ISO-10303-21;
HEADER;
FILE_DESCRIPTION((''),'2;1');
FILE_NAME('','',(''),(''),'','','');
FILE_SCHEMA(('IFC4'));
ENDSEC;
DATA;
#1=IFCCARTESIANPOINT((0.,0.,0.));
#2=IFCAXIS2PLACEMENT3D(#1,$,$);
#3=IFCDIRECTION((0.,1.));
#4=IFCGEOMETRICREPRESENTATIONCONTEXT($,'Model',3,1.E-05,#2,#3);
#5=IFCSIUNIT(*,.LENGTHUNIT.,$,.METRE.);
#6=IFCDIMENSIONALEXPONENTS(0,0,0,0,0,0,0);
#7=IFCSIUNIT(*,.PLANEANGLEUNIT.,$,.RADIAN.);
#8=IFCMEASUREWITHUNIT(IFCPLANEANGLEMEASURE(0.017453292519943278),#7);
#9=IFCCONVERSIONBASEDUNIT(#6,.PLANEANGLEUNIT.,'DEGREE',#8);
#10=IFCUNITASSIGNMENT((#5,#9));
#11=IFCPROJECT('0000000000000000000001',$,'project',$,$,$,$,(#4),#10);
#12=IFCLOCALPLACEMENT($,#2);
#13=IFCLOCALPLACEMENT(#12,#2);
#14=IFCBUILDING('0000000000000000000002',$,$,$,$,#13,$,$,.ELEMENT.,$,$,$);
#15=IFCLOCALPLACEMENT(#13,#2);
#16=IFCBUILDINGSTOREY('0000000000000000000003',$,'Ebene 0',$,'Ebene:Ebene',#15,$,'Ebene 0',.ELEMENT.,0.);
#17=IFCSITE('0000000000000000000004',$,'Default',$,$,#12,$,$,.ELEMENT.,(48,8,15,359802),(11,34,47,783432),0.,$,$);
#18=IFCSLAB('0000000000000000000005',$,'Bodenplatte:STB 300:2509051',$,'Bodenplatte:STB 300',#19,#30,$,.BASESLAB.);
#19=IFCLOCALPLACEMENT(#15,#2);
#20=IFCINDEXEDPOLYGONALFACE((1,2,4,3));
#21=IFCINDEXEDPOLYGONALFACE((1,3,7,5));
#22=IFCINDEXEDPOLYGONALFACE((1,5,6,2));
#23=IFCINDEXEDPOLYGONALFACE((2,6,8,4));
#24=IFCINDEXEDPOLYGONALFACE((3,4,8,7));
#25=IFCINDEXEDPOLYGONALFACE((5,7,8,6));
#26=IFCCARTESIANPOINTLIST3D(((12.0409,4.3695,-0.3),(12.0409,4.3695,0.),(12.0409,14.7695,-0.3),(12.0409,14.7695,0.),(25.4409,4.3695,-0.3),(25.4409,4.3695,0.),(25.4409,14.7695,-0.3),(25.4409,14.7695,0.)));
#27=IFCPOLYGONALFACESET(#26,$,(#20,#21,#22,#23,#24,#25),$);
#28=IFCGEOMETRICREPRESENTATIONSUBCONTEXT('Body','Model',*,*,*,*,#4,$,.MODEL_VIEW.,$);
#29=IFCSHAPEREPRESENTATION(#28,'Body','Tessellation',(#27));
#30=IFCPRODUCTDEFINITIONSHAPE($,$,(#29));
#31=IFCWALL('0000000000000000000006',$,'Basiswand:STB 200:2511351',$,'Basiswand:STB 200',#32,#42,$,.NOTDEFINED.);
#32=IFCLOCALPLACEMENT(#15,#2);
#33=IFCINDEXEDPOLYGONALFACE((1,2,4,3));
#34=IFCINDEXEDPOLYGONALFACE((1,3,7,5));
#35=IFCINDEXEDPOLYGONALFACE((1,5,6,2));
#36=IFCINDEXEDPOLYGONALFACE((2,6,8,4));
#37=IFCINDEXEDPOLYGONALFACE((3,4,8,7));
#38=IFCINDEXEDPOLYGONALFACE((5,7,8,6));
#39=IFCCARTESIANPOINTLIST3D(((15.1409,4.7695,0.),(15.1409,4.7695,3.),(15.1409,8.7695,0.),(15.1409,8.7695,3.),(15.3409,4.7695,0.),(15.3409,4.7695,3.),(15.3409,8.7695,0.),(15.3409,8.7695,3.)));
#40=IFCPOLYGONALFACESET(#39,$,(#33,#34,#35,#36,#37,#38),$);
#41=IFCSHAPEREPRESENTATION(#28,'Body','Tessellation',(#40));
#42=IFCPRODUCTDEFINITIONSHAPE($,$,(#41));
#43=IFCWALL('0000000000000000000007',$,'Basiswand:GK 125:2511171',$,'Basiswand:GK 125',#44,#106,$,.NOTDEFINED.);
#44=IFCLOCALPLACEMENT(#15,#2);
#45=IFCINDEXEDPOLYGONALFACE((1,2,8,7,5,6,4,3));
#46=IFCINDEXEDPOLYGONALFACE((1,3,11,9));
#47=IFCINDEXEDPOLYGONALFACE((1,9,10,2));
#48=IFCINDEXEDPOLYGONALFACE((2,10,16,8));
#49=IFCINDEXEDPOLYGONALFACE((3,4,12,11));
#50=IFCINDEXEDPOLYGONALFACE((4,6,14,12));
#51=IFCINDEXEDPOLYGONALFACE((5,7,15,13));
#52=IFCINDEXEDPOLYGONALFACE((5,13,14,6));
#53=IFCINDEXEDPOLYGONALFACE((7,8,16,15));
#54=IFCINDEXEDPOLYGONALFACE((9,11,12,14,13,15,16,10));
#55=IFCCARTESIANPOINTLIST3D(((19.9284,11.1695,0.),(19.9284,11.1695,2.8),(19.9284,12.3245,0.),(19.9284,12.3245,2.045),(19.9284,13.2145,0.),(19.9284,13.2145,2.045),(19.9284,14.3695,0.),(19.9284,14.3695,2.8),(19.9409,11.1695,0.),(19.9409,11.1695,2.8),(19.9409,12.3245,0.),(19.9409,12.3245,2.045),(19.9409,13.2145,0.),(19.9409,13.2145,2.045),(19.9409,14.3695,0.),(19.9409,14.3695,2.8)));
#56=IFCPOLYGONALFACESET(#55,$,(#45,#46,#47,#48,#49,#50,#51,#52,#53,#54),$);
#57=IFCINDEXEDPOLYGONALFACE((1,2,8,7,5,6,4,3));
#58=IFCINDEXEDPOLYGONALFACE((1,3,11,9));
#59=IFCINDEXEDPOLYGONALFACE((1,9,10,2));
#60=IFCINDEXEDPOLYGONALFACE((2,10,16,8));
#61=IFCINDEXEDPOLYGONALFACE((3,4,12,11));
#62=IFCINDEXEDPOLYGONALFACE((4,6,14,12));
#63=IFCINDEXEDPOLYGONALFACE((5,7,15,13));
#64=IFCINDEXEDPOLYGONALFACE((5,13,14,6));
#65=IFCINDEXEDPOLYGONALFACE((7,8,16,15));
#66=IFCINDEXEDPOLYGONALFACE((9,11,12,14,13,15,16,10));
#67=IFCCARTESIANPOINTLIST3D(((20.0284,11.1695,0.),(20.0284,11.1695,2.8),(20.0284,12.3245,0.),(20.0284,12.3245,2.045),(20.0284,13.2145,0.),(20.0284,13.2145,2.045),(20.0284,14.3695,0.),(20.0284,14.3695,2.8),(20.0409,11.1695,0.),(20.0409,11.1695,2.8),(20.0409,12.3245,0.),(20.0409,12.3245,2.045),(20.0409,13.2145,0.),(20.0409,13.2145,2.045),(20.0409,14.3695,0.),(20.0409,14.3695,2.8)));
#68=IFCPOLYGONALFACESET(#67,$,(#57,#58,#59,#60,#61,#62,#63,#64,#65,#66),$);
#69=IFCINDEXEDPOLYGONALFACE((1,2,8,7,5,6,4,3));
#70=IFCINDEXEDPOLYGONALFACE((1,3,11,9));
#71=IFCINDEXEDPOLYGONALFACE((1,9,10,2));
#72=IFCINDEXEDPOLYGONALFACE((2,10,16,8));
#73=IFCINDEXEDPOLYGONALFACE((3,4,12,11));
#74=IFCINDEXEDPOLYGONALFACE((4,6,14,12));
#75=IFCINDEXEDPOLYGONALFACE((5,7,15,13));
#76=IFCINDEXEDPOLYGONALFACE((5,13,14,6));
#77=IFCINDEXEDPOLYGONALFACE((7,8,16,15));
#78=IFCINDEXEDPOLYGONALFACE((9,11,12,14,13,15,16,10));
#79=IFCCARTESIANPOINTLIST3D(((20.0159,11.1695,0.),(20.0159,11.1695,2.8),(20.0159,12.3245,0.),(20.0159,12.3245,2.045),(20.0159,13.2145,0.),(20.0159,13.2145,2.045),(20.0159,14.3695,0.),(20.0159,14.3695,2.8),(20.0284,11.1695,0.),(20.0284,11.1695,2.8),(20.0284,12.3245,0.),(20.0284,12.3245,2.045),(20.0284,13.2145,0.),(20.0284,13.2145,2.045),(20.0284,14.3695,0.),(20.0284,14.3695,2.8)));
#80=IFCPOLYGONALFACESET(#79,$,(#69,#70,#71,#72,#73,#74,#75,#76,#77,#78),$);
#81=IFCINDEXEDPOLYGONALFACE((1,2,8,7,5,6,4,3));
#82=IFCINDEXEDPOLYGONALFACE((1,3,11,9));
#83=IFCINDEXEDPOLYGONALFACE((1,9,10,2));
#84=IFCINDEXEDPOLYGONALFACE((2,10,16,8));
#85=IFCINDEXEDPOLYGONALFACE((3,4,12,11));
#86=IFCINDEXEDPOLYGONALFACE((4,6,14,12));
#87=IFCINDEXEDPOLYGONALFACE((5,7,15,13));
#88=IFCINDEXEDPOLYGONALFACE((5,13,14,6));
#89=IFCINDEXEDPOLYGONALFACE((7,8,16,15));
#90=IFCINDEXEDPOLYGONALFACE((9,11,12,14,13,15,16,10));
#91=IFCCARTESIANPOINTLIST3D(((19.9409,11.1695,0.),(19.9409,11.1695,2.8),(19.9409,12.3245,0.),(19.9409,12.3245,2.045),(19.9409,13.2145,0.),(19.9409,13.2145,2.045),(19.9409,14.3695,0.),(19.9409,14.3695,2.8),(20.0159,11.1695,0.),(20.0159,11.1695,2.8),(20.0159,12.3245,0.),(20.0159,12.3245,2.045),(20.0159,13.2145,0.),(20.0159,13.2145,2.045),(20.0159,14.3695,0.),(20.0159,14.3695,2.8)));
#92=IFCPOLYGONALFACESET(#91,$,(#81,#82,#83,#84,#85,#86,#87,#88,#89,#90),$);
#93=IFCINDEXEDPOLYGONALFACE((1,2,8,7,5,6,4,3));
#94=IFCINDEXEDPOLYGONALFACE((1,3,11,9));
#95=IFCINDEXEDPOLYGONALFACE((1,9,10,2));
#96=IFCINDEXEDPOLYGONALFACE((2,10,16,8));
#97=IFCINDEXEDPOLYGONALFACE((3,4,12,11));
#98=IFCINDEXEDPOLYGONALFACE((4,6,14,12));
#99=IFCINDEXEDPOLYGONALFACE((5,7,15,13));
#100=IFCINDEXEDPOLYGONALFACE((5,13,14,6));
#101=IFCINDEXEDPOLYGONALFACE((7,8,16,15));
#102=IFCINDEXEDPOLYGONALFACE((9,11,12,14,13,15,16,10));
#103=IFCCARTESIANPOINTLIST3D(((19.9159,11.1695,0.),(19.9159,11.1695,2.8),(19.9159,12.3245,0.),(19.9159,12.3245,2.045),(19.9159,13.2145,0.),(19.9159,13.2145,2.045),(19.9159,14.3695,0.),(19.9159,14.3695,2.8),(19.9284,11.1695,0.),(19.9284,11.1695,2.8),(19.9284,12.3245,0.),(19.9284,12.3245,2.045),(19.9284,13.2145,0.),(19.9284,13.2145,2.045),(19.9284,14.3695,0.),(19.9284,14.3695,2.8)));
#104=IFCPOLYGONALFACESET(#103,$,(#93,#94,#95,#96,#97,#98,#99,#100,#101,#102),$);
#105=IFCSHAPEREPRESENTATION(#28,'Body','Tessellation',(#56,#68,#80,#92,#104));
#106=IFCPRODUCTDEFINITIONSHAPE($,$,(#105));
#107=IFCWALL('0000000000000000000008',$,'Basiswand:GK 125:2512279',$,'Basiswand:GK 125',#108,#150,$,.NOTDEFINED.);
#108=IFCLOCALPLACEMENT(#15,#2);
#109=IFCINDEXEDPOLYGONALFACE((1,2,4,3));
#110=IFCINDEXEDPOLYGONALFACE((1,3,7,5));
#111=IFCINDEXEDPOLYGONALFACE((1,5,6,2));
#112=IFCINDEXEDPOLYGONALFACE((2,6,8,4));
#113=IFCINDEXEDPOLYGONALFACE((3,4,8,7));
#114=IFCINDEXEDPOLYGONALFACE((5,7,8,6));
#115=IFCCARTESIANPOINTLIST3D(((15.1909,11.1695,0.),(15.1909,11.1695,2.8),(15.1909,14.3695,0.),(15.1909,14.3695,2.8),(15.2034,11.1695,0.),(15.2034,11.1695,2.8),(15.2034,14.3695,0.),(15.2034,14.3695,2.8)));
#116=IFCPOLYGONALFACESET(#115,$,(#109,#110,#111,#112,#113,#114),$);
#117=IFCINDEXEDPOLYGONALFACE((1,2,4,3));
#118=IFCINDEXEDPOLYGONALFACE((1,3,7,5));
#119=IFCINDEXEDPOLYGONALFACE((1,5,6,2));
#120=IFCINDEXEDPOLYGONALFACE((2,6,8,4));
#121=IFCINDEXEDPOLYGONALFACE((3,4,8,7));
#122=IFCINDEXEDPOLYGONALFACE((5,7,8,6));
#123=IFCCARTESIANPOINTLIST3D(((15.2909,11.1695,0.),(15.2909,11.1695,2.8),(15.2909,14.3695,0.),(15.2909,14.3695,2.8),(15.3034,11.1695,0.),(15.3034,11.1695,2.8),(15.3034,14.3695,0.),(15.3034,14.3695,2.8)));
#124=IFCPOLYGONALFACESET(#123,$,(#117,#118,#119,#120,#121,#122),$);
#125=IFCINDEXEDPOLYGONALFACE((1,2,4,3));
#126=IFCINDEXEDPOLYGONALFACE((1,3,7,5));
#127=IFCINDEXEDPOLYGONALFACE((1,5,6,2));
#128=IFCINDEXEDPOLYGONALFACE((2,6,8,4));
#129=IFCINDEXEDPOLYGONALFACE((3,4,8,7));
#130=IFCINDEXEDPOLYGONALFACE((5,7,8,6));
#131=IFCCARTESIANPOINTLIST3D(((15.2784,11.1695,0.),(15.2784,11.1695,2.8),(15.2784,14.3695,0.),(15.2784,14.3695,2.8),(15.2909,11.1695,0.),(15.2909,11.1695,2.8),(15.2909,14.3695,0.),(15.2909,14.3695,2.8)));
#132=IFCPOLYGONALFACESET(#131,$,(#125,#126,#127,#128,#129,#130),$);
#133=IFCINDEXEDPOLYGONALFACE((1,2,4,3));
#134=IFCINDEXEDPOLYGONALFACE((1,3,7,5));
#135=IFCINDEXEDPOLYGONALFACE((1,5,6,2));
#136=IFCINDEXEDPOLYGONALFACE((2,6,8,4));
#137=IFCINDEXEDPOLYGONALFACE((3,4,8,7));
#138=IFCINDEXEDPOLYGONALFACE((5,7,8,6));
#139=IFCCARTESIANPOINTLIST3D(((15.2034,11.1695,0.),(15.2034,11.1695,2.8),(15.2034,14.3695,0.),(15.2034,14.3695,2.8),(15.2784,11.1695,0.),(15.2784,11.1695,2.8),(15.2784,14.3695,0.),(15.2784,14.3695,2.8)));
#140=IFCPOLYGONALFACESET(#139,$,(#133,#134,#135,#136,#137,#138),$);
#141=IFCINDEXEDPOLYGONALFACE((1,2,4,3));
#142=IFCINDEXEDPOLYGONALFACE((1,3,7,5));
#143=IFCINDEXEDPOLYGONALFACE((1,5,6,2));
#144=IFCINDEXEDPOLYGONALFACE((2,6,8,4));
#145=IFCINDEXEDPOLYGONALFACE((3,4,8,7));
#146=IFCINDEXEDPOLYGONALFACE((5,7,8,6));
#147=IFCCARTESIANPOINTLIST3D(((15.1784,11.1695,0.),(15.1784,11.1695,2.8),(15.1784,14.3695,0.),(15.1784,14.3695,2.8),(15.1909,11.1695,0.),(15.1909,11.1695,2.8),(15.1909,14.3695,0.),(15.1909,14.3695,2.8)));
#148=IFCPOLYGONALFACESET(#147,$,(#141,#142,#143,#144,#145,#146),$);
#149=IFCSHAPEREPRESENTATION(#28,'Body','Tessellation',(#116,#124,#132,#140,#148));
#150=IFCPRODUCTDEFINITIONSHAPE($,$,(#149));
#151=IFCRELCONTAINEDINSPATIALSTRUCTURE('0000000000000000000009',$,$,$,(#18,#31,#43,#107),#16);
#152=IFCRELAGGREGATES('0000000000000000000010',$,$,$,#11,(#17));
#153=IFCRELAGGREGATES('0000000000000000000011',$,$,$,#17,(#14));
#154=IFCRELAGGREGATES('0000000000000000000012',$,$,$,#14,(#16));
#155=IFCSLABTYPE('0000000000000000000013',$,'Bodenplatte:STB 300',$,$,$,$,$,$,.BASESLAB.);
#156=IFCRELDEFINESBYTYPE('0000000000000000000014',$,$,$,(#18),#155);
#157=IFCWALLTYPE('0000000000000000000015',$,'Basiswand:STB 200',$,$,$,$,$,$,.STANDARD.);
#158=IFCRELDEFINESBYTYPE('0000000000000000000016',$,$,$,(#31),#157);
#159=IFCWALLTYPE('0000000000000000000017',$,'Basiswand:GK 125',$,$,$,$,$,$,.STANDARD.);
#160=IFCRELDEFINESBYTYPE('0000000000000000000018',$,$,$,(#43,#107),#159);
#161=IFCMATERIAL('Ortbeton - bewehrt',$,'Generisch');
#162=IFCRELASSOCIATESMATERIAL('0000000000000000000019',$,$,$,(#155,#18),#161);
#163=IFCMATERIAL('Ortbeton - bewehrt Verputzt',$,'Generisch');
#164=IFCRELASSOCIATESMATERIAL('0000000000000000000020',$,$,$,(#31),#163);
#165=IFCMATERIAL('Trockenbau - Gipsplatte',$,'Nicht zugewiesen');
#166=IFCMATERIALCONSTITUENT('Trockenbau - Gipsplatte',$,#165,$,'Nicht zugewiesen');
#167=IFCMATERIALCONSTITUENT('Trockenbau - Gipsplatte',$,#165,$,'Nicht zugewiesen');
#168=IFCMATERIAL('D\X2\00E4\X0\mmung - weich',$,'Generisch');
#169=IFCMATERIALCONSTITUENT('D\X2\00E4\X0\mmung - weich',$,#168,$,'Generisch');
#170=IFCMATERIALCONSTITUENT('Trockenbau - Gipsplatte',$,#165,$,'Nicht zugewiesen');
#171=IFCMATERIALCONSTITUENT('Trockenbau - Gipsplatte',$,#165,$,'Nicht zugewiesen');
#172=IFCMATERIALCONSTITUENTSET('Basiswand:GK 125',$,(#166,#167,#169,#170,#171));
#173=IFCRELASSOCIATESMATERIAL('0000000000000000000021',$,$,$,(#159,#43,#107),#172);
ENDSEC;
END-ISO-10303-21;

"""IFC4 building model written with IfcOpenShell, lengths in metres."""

from ifc_helpers import new_model, entity, si_unit, converted_unit, direction, frame, origin, place, context, subcontext, project, spatial, indexed_curve, outline, extrude, material, constituent, constituent_set, type_object, element, save


model = new_model("IFC4")

# Units and contexts
model_context = context("Model", 3, precision=1e-05, world=origin(), true_north=direction((0.0, 1.0)))
body_context = subcontext(model_context, "Body", "Model", "MODEL_VIEW")
ifc_project = project(units=[si_unit("LENGTHUNIT", "METRE"), converted_unit("PLANEANGLEUNIT", "DEGREE", entity("IfcPlaneAngleMeasure", 0.017453292519943278), si_unit("PLANEANGLEUNIT", "RADIAN"), dimensions=[0, 0, 0, 0, 0, 0, 0])], contexts=[model_context])

# Site, building, storey
site_placement = place(None, origin())
site = spatial("IfcSite", under=ifc_project, at=site_placement, Name="Default", CompositionType="ELEMENT", RefLatitude=(48, 8, 15, 359802), RefLongitude=(11, 34, 47, 783432), RefElevation=0.0)
building_placement = place(site_placement, origin())
building = spatial("IfcBuilding", under=site, at=building_placement, CompositionType="ELEMENT")
storey_placement = place(building_placement, origin())
storey = spatial("IfcBuildingStorey", under=building, at=storey_placement, Name="Ebene 0", ObjectType="Ebene:Ebene", LongName="Ebene 0", CompositionType="ELEMENT", Elevation=0.0)

# Slab
ifc_material_1 = material(Name="Ortbeton - bewehrt", Category="Generisch")
slab_type_1 = type_object("IfcSlabType", Name="Bodenplatte:STB 300", PredefinedType="BASESLAB", material=ifc_material_1)
slab_1_placement = place(storey_placement, origin())
element("IfcSlab", 1, at=slab_1_placement, inside=storey, type_object=slab_type_1, material=ifc_material_1, Name="Bodenplatte:STB 300:2509051", ObjectType="Bodenplatte:STB 300", PredefinedType="BASESLAB", context=body_context, shape_type="SweptSolid", body=[
    extrude(outline(indexed_curve([(-5.2, -6.7), (5.2, -6.7), (5.2, 6.7), (-5.2, 6.7), (-5.2, -6.7)], self_intersect=False)), frame((18.7409, 9.5695, 0.0), z_axis=(0.0, 0.0, -1.0), x_axis=(0.0, 1.0, 0.0)), (0.0, 0.0, 1.0), 0.3),
])

# Wall
ifc_material_2 = material(Name="Ortbeton - bewehrt Verputzt", Category="Generisch")
wall_type_1 = type_object("IfcWallType", Name="Basiswand:STB 200", PredefinedType="STANDARD")
wall_1_placement = place(storey_placement, frame((15.2409, 8.7695, 0.0), z_axis=(0.0, 0.0, 1.0), x_axis=(0.0, -1.0, 0.0)))
element("IfcWall", 2, at=wall_1_placement, inside=storey, type_object=wall_type_1, material=ifc_material_2, Name="Basiswand:STB 200:2511351", ObjectType="Basiswand:STB 200", PredefinedType="NOTDEFINED", context=body_context, shape_type="SweptSolid", body=[
    extrude(outline(indexed_curve([(4.0, 0.1), (0.0, 0.1), (0.0, -0.1), (4.0, -0.1), (4.0, 0.1)], self_intersect=False)), origin(), (0.0, 0.0, 1.0), 3.0),
])

# Wall, opening
ifc_material_3 = material(Name="Trockenbau - Gipsplatte", Category="Nicht zugewiesen")
ifc_constituent_1 = constituent(ifc_material_3, Name="Trockenbau - Gipsplatte", Category="Nicht zugewiesen")
ifc_constituent_2 = constituent(ifc_material_3, Name="Trockenbau - Gipsplatte", Category="Nicht zugewiesen")
ifc_material_4 = material(Name="Dämmung - weich", Category="Generisch")
ifc_constituent_3 = constituent(ifc_material_4, Name="Dämmung - weich", Category="Generisch")
ifc_constituent_4 = constituent(ifc_material_3, Name="Trockenbau - Gipsplatte", Category="Nicht zugewiesen")
ifc_constituent_5 = constituent(ifc_material_3, Name="Trockenbau - Gipsplatte", Category="Nicht zugewiesen")
ifc_constituent_set_1 = constituent_set(constituents=[ifc_constituent_1, ifc_constituent_2, ifc_constituent_3, ifc_constituent_4, ifc_constituent_5], Name="Basiswand:GK 125")
wall_type_2 = type_object("IfcWallType", Name="Basiswand:GK 125", PredefinedType="STANDARD", material=ifc_constituent_set_1)
wall_2_placement = place(storey_placement, frame((19.9784, 14.3695, 0.0), z_axis=(0.0, 0.0, 1.0), x_axis=(0.0, -1.0, 0.0)))
wall_2 = element("IfcWall", 3, at=wall_2_placement, inside=storey, type_object=wall_type_2, material=ifc_constituent_set_1, Name="Basiswand:GK 125:2511171", ObjectType="Basiswand:GK 125", PredefinedType="NOTDEFINED", context=body_context, shape_type="SweptSolid", body=[
    extrude(outline(indexed_curve([(-1.2112, -1.6), (1.5888, -1.6), (1.5888, 1.6), (-1.2112, 1.6), (-1.2112, 0.445), (0.8337, 0.445), (0.8337, -0.445), (-1.2112, -0.445), (-1.2112, -1.6)], self_intersect=False)), frame((1.6, -0.05, 1.2112), z_axis=(0.0, 1.0, 0.0), x_axis=(0.0, 0.0, 1.0)), (0.0, 0.0, 1.0), 0.0125),
    extrude(outline(indexed_curve([(-1.2112, -1.6), (1.5888, -1.6), (1.5888, 1.6), (-1.2112, 1.6), (-1.2112, 0.445), (0.8337, 0.445), (0.8337, -0.445), (-1.2112, -0.445), (-1.2112, -1.6)], self_intersect=False)), frame((1.6, 0.05, 1.2112), z_axis=(0.0, 1.0, 0.0), x_axis=(0.0, 0.0, 1.0)), (0.0, 0.0, 1.0), 0.0125),
    extrude(outline(indexed_curve([(-1.2112, -1.6), (1.5888, -1.6), (1.5888, 1.6), (-1.2112, 1.6), (-1.2112, 0.445), (0.8337, 0.445), (0.8337, -0.445), (-1.2112, -0.445), (-1.2112, -1.6)], self_intersect=False)), frame((1.6, 0.0375, 1.2112), z_axis=(0.0, 1.0, 0.0), x_axis=(0.0, 0.0, 1.0)), (0.0, 0.0, 1.0), 0.0125),
    extrude(outline(indexed_curve([(-1.2112, -1.6), (1.5888, -1.6), (1.5888, 1.6), (-1.2112, 1.6), (-1.2112, 0.445), (0.8337, 0.445), (0.8337, -0.445), (-1.2112, -0.445), (-1.2112, -1.6)], self_intersect=False)), frame((1.6, -0.0375, 1.2112), z_axis=(0.0, 1.0, 0.0), x_axis=(0.0, 0.0, 1.0)), (0.0, 0.0, 1.0), 0.075),
    extrude(outline(indexed_curve([(-1.5888, -1.6), (1.2112, -1.6), (1.2112, -0.445), (-0.8337, -0.445), (-0.8337, 0.445), (1.2112, 0.445), (1.2112, 1.6), (-1.5888, 1.6), (-1.5888, -1.6)], self_intersect=False)), frame((1.6, -0.0625, 1.2112), z_axis=(0.0, 1.0, 0.0), x_axis=(0.0, 0.0, -1.0)), (0.0, 0.0, 1.0), 0.0125),
])
opening_1_placement = place(wall_2_placement, frame((2.045, 0.0625, -0.18)))
element("IfcOpeningElement", 4, at=opening_1_placement, cuts=wall_2, PredefinedType="OPENING", context=body_context, shape_type="SweptSolid", body=[
    extrude(outline(indexed_curve([(2.225, 0.89), (0.0, 0.89), (0.0, 0.0), (2.225, 0.0), (2.225, 0.89)], self_intersect=False)), frame((0.0, 0.0, 0.0), z_axis=(0.0, -1.0, 0.0), x_axis=(0.0, 0.0, 1.0)), (0.0, 0.0, 1.0), 0.125),
])

# Wall
wall_3_placement = place(storey_placement, frame((15.2409, 14.3695, 0.0), z_axis=(0.0, 0.0, 1.0), x_axis=(0.0, -1.0, 0.0)))
element("IfcWall", 5, at=wall_3_placement, inside=storey, type_object=wall_type_2, material=ifc_constituent_set_1, Name="Basiswand:GK 125:2512279", ObjectType="Basiswand:GK 125", PredefinedType="NOTDEFINED", context=body_context, shape_type="SweptSolid", body=[
    extrude(outline(indexed_curve([(-1.6, -0.0062), (1.6, -0.0063), (1.6, 0.0062), (-1.6, 0.0063), (-1.6, -0.0062)], self_intersect=False)), frame((1.6, -0.0438, 0.0)), (0.0, 0.0, 1.0), 2.8),
    extrude(outline(indexed_curve([(-0.0063, -1.6), (0.0062, -1.6), (0.0063, 1.6), (-0.0062, 1.6), (-0.0063, -1.6)], self_intersect=False)), frame((1.6, 0.0562, 0.0), z_axis=(0.0, 0.0, 1.0), x_axis=(0.0, -1.0, 0.0)), (0.0, 0.0, 1.0), 2.8),
    extrude(outline(indexed_curve([(-1.6, -0.0062), (1.6, -0.0063), (1.6, 0.0062), (-1.6, 0.0063), (-1.6, -0.0062)], self_intersect=False)), frame((1.6, 0.0437, 0.0)), (0.0, 0.0, 1.0), 2.8),
    extrude(outline(indexed_curve([(-1.6, -0.0375), (1.6, -0.0375), (1.6, 0.0375), (-1.6, 0.0375), (-1.6, -0.0375)], self_intersect=False)), frame((1.6, 0.0, 0.0)), (0.0, 0.0, 1.0), 2.8),
    extrude(outline(indexed_curve([(-0.0063, -1.6), (0.0062, -1.6), (0.0063, 1.6), (-0.0062, 1.6), (-0.0063, -1.6)], self_intersect=False)), frame((1.6, -0.0562, 0.0), z_axis=(0.0, 0.0, 1.0), x_axis=(0.0, 1.0, 0.0)), (0.0, 0.0, 1.0), 2.8),
])

save(model, "model.ifc")
